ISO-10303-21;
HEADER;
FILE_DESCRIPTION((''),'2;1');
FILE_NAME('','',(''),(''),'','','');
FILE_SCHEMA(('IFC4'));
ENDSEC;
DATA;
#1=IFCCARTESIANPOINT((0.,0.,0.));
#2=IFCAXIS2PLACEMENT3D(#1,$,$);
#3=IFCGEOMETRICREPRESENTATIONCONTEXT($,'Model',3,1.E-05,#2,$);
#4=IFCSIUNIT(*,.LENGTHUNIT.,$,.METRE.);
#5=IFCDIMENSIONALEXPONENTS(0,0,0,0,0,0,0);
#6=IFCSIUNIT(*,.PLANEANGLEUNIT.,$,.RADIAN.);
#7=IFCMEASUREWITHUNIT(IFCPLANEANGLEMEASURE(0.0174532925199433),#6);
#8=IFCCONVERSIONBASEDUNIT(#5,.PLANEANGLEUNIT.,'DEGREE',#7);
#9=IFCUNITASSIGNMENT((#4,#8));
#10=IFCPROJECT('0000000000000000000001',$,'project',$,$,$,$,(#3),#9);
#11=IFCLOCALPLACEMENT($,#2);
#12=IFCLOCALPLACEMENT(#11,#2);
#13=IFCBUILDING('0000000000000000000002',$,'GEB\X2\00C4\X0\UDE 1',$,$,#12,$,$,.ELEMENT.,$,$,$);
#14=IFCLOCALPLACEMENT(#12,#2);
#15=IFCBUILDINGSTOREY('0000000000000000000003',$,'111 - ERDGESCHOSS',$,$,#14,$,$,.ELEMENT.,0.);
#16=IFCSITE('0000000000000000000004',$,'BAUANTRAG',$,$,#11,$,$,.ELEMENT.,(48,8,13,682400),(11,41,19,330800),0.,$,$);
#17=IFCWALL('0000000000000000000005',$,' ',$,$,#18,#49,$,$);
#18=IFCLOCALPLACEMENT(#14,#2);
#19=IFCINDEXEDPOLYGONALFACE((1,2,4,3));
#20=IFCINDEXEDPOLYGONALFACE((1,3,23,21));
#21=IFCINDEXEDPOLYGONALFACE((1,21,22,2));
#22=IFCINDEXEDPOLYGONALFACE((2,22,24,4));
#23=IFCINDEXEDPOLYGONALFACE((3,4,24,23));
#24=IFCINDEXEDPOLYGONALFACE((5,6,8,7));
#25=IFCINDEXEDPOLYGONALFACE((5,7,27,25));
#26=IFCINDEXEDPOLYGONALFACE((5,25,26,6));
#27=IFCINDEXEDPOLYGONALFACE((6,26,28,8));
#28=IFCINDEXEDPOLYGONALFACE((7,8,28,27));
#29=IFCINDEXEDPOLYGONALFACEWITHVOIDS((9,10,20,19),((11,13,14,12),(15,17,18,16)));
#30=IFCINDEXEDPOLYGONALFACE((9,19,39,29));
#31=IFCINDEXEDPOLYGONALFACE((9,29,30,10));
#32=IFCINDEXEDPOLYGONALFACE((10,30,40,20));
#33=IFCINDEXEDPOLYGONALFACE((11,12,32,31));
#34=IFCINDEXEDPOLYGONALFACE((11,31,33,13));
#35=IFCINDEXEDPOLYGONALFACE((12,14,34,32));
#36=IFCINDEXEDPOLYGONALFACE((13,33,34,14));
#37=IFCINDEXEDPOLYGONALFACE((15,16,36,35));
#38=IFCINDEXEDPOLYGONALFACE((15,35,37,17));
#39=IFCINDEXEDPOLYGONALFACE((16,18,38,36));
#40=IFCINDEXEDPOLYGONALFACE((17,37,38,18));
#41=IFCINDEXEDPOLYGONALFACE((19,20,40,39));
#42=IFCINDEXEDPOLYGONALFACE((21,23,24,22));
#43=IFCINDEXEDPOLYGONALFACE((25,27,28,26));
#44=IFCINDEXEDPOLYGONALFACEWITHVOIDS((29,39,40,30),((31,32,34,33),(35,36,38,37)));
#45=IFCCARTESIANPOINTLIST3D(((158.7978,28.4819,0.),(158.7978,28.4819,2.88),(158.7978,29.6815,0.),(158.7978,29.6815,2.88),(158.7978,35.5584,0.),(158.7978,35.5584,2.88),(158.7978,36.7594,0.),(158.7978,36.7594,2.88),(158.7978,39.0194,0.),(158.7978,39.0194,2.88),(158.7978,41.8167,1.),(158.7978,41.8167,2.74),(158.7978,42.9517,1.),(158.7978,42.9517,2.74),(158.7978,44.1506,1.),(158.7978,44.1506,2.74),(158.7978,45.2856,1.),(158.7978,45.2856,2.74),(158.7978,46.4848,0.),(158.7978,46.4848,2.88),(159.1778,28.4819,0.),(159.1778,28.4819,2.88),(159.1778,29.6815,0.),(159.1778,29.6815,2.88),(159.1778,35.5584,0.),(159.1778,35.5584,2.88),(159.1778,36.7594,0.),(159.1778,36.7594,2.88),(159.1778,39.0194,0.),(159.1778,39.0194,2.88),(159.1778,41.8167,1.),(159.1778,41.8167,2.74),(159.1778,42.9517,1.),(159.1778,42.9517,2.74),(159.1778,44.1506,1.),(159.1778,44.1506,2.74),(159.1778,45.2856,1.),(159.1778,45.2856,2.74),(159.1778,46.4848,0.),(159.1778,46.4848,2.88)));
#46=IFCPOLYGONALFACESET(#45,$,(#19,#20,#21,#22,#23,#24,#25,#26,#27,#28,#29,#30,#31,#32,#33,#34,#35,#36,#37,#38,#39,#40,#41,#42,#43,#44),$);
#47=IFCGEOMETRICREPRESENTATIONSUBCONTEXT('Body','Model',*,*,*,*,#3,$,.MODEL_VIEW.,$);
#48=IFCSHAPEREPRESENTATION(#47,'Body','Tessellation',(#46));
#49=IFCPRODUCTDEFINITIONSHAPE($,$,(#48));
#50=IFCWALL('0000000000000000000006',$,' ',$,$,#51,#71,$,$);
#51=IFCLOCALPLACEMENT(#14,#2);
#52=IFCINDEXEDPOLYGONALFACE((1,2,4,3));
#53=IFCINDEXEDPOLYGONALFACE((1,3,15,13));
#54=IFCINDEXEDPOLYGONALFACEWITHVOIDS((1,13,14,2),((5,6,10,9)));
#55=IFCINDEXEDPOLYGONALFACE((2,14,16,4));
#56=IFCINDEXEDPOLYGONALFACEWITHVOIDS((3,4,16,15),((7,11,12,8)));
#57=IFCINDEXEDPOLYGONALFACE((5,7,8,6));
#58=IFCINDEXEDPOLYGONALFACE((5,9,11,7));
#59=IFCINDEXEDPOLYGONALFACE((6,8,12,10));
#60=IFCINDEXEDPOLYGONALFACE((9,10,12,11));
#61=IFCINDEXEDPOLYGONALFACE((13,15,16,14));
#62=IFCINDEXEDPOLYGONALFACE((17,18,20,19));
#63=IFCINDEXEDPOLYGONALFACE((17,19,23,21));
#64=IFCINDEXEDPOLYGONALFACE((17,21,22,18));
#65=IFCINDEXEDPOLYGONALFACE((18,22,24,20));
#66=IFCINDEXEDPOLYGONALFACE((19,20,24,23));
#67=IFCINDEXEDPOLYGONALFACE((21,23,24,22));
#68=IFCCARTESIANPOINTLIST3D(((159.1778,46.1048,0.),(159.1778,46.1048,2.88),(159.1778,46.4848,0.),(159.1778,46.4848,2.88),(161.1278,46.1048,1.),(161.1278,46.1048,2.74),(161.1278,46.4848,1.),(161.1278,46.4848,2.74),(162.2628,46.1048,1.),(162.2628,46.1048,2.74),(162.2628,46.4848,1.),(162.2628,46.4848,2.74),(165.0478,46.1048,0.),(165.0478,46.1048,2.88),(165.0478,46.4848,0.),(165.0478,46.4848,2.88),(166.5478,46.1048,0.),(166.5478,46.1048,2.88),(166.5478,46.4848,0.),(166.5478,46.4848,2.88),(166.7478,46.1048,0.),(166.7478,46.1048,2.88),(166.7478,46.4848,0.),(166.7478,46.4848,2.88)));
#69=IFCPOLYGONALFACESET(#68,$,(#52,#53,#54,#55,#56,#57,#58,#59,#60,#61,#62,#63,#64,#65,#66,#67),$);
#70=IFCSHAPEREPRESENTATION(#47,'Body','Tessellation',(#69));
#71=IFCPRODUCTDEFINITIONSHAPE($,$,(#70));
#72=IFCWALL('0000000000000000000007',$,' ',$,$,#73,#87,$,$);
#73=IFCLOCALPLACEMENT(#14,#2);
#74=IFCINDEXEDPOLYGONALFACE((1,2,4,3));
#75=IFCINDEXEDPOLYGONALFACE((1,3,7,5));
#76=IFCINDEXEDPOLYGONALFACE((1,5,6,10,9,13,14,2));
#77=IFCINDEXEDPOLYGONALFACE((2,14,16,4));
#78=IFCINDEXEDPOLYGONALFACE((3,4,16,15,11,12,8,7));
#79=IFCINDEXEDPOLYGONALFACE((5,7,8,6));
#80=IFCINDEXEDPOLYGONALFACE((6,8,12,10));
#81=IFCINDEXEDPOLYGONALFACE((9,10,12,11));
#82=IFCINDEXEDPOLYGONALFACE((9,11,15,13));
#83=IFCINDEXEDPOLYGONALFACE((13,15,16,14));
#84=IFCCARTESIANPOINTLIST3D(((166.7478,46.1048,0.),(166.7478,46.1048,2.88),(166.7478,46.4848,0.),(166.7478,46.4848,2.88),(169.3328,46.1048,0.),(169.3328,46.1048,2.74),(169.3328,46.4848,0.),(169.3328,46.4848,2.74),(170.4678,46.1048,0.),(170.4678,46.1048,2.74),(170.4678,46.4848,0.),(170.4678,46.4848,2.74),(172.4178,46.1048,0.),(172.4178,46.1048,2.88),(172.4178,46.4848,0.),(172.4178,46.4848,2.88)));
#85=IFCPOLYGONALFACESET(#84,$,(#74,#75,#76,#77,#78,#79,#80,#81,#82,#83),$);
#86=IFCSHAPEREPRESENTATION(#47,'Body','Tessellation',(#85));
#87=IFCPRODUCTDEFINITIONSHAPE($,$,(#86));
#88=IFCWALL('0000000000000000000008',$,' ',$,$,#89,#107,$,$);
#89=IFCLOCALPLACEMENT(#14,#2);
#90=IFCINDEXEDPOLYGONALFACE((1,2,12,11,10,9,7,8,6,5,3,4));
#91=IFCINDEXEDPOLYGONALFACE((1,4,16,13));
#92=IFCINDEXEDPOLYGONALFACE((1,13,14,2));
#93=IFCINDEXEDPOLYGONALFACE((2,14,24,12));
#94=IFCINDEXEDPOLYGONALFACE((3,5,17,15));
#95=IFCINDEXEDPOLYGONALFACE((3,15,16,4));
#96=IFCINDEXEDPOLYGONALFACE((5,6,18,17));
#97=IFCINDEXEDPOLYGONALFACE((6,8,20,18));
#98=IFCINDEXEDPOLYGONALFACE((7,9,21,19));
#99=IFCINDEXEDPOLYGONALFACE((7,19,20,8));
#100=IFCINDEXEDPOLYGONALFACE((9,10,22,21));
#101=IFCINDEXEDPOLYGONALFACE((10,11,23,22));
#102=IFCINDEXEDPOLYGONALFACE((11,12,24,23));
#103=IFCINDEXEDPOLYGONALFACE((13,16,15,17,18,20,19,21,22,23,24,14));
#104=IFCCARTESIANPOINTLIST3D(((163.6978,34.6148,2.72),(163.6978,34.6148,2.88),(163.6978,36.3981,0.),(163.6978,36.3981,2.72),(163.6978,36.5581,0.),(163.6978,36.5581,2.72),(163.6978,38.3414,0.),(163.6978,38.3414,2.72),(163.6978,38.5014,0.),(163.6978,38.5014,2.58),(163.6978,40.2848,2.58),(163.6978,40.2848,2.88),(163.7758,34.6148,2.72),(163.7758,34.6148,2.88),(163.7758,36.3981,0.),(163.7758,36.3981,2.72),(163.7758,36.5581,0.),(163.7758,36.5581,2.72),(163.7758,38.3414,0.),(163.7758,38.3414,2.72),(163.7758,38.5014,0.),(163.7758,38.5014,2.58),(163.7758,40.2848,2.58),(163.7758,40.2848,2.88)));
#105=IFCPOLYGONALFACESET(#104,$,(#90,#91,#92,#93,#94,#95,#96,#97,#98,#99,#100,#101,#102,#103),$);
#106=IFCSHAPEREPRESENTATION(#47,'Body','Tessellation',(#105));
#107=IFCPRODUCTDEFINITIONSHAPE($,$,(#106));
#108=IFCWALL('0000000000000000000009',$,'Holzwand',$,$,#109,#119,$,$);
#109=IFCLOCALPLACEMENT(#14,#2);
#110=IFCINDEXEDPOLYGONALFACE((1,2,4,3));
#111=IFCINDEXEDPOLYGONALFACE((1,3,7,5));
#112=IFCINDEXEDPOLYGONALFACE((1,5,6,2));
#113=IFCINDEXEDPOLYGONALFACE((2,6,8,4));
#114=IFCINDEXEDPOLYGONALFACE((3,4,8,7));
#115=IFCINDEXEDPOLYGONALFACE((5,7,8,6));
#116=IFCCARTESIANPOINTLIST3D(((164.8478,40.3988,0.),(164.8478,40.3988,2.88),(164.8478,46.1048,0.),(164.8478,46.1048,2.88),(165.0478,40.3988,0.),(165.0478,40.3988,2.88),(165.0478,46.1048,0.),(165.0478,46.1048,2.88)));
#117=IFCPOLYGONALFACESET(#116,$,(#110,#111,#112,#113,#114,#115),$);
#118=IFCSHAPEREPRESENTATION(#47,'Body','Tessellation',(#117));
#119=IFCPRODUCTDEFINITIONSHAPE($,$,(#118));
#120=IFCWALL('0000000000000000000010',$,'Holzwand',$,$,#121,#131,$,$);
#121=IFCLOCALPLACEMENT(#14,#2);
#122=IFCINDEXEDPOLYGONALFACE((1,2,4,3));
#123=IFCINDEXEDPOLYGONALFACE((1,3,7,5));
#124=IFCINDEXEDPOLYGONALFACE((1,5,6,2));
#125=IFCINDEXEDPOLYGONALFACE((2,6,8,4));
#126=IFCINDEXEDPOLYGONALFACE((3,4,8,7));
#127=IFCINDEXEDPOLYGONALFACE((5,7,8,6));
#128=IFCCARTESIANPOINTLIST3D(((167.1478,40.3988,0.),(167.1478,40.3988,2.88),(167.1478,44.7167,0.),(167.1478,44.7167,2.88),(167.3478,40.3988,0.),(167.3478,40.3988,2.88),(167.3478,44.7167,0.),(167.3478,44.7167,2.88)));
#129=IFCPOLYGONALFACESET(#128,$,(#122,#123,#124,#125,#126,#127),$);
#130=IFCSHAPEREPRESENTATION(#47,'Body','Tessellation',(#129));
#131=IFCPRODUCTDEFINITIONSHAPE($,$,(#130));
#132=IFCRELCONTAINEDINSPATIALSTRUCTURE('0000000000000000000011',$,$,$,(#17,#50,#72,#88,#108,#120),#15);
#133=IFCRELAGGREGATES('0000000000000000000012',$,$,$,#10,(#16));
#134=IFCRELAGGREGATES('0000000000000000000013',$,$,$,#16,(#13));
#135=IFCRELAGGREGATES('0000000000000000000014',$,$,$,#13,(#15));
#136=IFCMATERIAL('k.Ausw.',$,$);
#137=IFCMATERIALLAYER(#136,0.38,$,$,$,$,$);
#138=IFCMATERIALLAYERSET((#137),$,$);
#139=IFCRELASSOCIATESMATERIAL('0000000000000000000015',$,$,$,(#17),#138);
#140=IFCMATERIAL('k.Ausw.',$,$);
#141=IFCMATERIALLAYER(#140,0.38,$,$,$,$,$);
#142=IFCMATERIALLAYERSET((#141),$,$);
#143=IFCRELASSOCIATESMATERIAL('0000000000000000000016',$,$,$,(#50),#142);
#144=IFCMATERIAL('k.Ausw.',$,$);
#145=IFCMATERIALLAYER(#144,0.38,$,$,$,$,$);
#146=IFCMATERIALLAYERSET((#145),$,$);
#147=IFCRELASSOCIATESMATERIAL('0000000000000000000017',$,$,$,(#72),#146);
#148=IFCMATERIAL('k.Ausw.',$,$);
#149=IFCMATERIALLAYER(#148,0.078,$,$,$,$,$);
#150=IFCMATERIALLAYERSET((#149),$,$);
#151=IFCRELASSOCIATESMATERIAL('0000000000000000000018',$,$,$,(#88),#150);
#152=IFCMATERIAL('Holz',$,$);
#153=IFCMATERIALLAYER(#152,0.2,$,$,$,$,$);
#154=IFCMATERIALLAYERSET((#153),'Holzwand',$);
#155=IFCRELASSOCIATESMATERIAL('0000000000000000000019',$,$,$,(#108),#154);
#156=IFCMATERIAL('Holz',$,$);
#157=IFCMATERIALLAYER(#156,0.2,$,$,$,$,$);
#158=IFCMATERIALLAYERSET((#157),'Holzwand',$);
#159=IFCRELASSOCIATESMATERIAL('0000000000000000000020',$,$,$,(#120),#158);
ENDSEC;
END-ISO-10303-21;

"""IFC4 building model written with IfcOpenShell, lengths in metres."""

from ifc_helpers import new_model, entity, si_unit, converted_unit, frame, frame_2d, origin, origin_with_axes, place, context, subcontext, project, spatial, polyline, rectangle, outline, extrude, material, layer, layer_set, layer_usage, element, save


model = new_model("IFC4")

# Units and contexts
model_context = context("Model", 3, precision=1e-05, world=origin())
body_context = subcontext(model_context, "Body", "Model", "MODEL_VIEW")
ifc_project = project(units=[si_unit("LENGTHUNIT", "METRE"), converted_unit("PLANEANGLEUNIT", "DEGREE", entity("IfcPlaneAngleMeasure", 0.0174532925199433), si_unit("PLANEANGLEUNIT", "RADIAN"), dimensions=[0, 0, 0, 0, 0, 0, 0])], contexts=[model_context])

# Site, building, storey
site_placement = place(None, origin())
site = spatial("IfcSite", under=ifc_project, at=site_placement, Name="BAUANTRAG", CompositionType="ELEMENT", RefLatitude=(48, 8, 13, 682400), RefLongitude=(11, 41, 19, 330800), RefElevation=0.0)
building_placement = place(site_placement, origin())
building = spatial("IfcBuilding", under=site, at=building_placement, Name="GEBÄUDE 1", CompositionType="ELEMENT")
storey_placement = place(building_placement, origin())
storey = spatial("IfcBuildingStorey", under=building, at=storey_placement, Name="111 - ERDGESCHOSS", CompositionType="ELEMENT", Elevation=0.0)

# Walls, openings
ifc_material_1 = material(Name="k.Ausw.")
ifc_layer_1 = layer(ifc_material_1, 0.38)
ifc_layer_set_1 = layer_set([ifc_layer_1])
ifc_layer_usage_1 = layer_usage(ifc_layer_set_1, "AXIS2", "POSITIVE", 0.0)
wall_1_placement = place(storey_placement, frame((158.7978, 46.4848, 0.0), z_axis=(0.0, 0.0, 1.0), x_axis=(0.0, -1.0, 0.0)))
wall_1 = element("IfcWall", 1, at=wall_1_placement, inside=storey, material=ifc_layer_usage_1, Name=" ", context=body_context, shape_type="SweptSolid", body=[
    extrude(rectangle(XDim=18.0029, YDim=0.38, at=frame_2d((9.0014, 0.19), x_axis=(1.0, 0.0))), origin_with_axes(), (0.0, 0.0, 1.0), 2.88),
])
opening_1_placement = place(wall_1_placement, frame((1.1992, 0.0, 1.0), z_axis=(0.0, 1.0, 0.0), x_axis=(0.0, 0.0, 1.0)))
element("IfcOpeningElement", 2, at=opening_1_placement, cuts=wall_1, ObjectType="Opening", context=body_context, shape_type="SweptSolid", body=[
    extrude(outline(polyline([(0.0, 1.135), (1.74, 1.135), (1.74, 0.0), (0.0, 0.0), (0.0, 1.135)])), origin_with_axes(), (0.0, 0.0, 1.0), 0.38),
])
opening_2_placement = place(wall_1_placement, frame((3.5331, 0.0, 1.0), z_axis=(0.0, 1.0, 0.0), x_axis=(0.0, 0.0, 1.0)))
element("IfcOpeningElement", 3, at=opening_2_placement, cuts=wall_1, ObjectType="Opening", context=body_context, shape_type="SweptSolid", body=[
    extrude(outline(polyline([(0.0, 1.135), (1.74, 1.135), (1.74, 0.0), (0.0, 0.0), (0.0, 1.135)])), origin_with_axes(), (0.0, 0.0, 1.0), 0.38),
])
opening_3_placement = place(wall_1_placement, frame((12.0614, 0.0, 0.0), z_axis=(0.0, 1.0, 0.0), x_axis=(0.0, 0.0, 1.0)))
element("IfcOpeningElement", 4, at=opening_3_placement, cuts=wall_1, ObjectType="Opening", context=body_context, shape_type="SweptSolid", body=[
    extrude(outline(polyline([(0.0, 3.608), (2.88, 3.608), (2.88, 0.0), (0.0, 0.0), (0.0, 3.608)])), origin_with_axes(), (0.0, 0.0, 1.0), 0.38),
])
opening_4_placement = place(wall_1_placement, frame((10.9264, 0.0, 0.0), z_axis=(0.0, 1.0, 0.0), x_axis=(0.0, 0.0, 1.0)))
element("IfcOpeningElement", 5, at=opening_4_placement, cuts=wall_1, ObjectType="Opening", context=body_context, shape_type="SweptSolid", body=[
    extrude(outline(polyline([(0.0, 1.135), (2.88, 1.135), (2.88, 0.0), (0.0, 0.0), (0.0, 1.135)])), origin_with_axes(), (0.0, 0.0, 1.0), 0.38),
])
opening_5_placement = place(wall_1_placement, frame((15.6683, 0.0, 0.0), z_axis=(0.0, 1.0, 0.0), x_axis=(0.0, 0.0, 1.0)))
element("IfcOpeningElement", 6, at=opening_5_placement, cuts=wall_1, ObjectType="Opening", context=body_context, shape_type="SweptSolid", body=[
    extrude(outline(polyline([(0.0, 1.135), (2.88, 1.135), (2.88, 0.0), (0.0, 0.0), (0.0, 1.135)])), origin_with_axes(), (0.0, 0.0, 1.0), 0.38),
])
opening_6_placement = place(wall_1_placement, frame((7.4654, 0.0, 0.0), z_axis=(0.0, 1.0, 0.0), x_axis=(0.0, 0.0, 1.0)))
element("IfcOpeningElement", 7, at=opening_6_placement, cuts=wall_1, ObjectType="Opening", context=body_context, shape_type="SweptSolid", body=[
    extrude(outline(polyline([(0.0, 2.26), (2.88, 2.26), (2.88, 0.0), (0.0, 0.0), (0.0, 2.26)])), origin_with_axes(), (0.0, 0.0, 1.0), 0.38),
])
ifc_material_2 = material(Name="k.Ausw.")
ifc_layer_2 = layer(ifc_material_2, 0.38)
ifc_layer_set_2 = layer_set([ifc_layer_2])
ifc_layer_usage_2 = layer_usage(ifc_layer_set_2, "AXIS2", "POSITIVE", 0.0)
wall_2_placement = place(storey_placement, frame((166.7478, 46.4848, 0.0), z_axis=(0.0, 0.0, 1.0), x_axis=(-1.0, 0.0, 0.0)))
wall_2 = element("IfcWall", 8, at=wall_2_placement, inside=storey, material=ifc_layer_usage_2, Name=" ", context=body_context, shape_type="SweptSolid", body=[
    extrude(rectangle(XDim=7.57, YDim=0.38, at=frame_2d((3.785, 0.19), x_axis=(1.0, 0.0))), origin_with_axes(), (0.0, 0.0, 1.0), 2.88),
])
opening_7_placement = place(wall_2_placement, frame((0.2, 0.0, -0.15), z_axis=(0.0, 1.0, 0.0), x_axis=(0.0, 0.0, 1.0)))
element("IfcOpeningElement", 9, at=opening_7_placement, cuts=wall_2, ObjectType="Opening", context=body_context, shape_type="SweptSolid", body=[
    extrude(outline(polyline([(0.0, 1.5), (3.03, 1.5), (3.03, 0.0), (0.0, 0.0), (0.0, 1.5)])), origin_with_axes(), (0.0, 0.0, 1.0), 0.38),
])
opening_8_placement = place(wall_2_placement, frame((5.62, 0.38, 1.0), z_axis=(0.0, -1.0, 0.0), x_axis=(0.0, 0.0, 1.0)))
element("IfcOpeningElement", 10, at=opening_8_placement, cuts=wall_2, ObjectType="Opening", context=body_context, shape_type="SweptSolid", body=[
    extrude(outline(polyline([(0.0, 1.135), (1.74, 1.135), (1.74, 0.0), (0.0, 0.0), (0.0, 1.135)])), origin_with_axes(), (0.0, 0.0, 1.0), 0.38),
])

# Wall, opening
ifc_material_3 = material(Name="k.Ausw.")
ifc_layer_3 = layer(ifc_material_3, 0.38)
ifc_layer_set_3 = layer_set([ifc_layer_3])
ifc_layer_usage_3 = layer_usage(ifc_layer_set_3, "AXIS2", "POSITIVE", 0.0)
wall_3_placement = place(storey_placement, frame((172.4178, 46.4848, 0.0), z_axis=(0.0, 0.0, 1.0), x_axis=(-1.0, 0.0, 0.0)))
wall_3 = element("IfcWall", 11, at=wall_3_placement, inside=storey, material=ifc_layer_usage_3, Name=" ", context=body_context, shape_type="SweptSolid", body=[
    extrude(rectangle(XDim=5.67, YDim=0.38, at=frame_2d((2.835, 0.19), x_axis=(1.0, 0.0))), origin_with_axes(), (0.0, 0.0, 1.0), 2.88),
])
opening_9_placement = place(wall_3_placement, frame((3.085, 0.38, 0.0), z_axis=(0.0, -1.0, 0.0), x_axis=(0.0, 0.0, 1.0)))
element("IfcOpeningElement", 12, at=opening_9_placement, cuts=wall_3, ObjectType="Opening", context=body_context, shape_type="SweptSolid", body=[
    extrude(outline(polyline([(0.0, 1.135), (2.74, 1.135), (2.74, 0.0), (0.0, 0.0), (0.0, 1.135)])), origin_with_axes(), (0.0, 0.0, 1.0), 0.38),
])

# Wall, openings
ifc_material_4 = material(Name="k.Ausw.")
ifc_layer_4 = layer(ifc_material_4, 0.078)
ifc_layer_set_4 = layer_set([ifc_layer_4])
ifc_layer_usage_4 = layer_usage(ifc_layer_set_4, "AXIS2", "POSITIVE", 0.0)
wall_4_placement = place(storey_placement, frame((163.6978, 40.2848, 0.0), z_axis=(0.0, 0.0, 1.0), x_axis=(0.0, -1.0, 0.0)))
wall_4 = element("IfcWall", 13, at=wall_4_placement, inside=storey, material=ifc_layer_usage_4, Name=" ", context=body_context, shape_type="SweptSolid", body=[
    extrude(rectangle(XDim=5.67, YDim=0.078, at=frame_2d((2.835, 0.039), x_axis=(1.0, 0.0))), origin_with_axes(), (0.0, 0.0, 1.0), 2.88),
])
opening_10_placement = place(wall_4_placement, frame((3.8867, 0.0, 0.0), z_axis=(0.0, 1.0, 0.0), x_axis=(0.0, 0.0, 1.0)))
element("IfcOpeningElement", 14, at=opening_10_placement, cuts=wall_4, ObjectType="Opening", context=body_context, shape_type="SweptSolid", body=[
    extrude(outline(polyline([(0.0, 1.7833), (2.72, 1.7833), (2.72, 0.0), (0.0, 0.0), (0.0, 1.7833)])), origin_with_axes(), (0.0, 0.0, 1.0), 0.078),
])
opening_11_placement = place(wall_4_placement, frame((0.0, 0.0, -0.14), z_axis=(0.0, 1.0, 0.0), x_axis=(0.0, 0.0, 1.0)))
element("IfcOpeningElement", 15, at=opening_11_placement, cuts=wall_4, ObjectType="Opening", context=body_context, shape_type="SweptSolid", body=[
    extrude(outline(polyline([(0.0, 1.7834), (2.72, 1.7834), (2.72, 0.0), (0.0, 0.0), (0.0, 1.7834)])), origin_with_axes(), (0.0, 0.0, 1.0), 0.078),
])
opening_12_placement = place(wall_4_placement, frame((1.9434, 0.0, 0.0), z_axis=(0.0, 1.0, 0.0), x_axis=(0.0, 0.0, 1.0)))
element("IfcOpeningElement", 16, at=opening_12_placement, cuts=wall_4, ObjectType="Opening", context=body_context, shape_type="SweptSolid", body=[
    extrude(outline(polyline([(0.0, 1.7833), (2.72, 1.7833), (2.72, 0.0), (0.0, 0.0), (0.0, 1.7833)])), origin_with_axes(), (0.0, 0.0, 1.0), 0.078),
])

# Walls
ifc_material_5 = material(Name="Holz")
ifc_layer_5 = layer(ifc_material_5, 0.2)
ifc_layer_set_5 = layer_set([ifc_layer_5], Name="Holzwand")
ifc_layer_usage_5 = layer_usage(ifc_layer_set_5, "AXIS2", "POSITIVE", 0.0)
wall_5_placement = place(storey_placement, frame((164.8478, 46.1048, 0.0), z_axis=(0.0, 0.0, 1.0), x_axis=(0.0, -1.0, 0.0)))
element("IfcWall", 17, at=wall_5_placement, inside=storey, material=ifc_layer_usage_5, Name="Holzwand", context=body_context, shape_type="SweptSolid", body=[
    extrude(rectangle(XDim=5.706, YDim=0.2, at=frame_2d((2.853, 0.1), x_axis=(1.0, 0.0))), origin_with_axes(), (0.0, 0.0, 1.0), 2.88),
])
ifc_material_6 = material(Name="Holz")
ifc_layer_6 = layer(ifc_material_6, 0.2)
ifc_layer_set_6 = layer_set([ifc_layer_6], Name="Holzwand")
ifc_layer_usage_6 = layer_usage(ifc_layer_set_6, "AXIS2", "POSITIVE", 0.0)
wall_6_placement = place(storey_placement, frame((167.1478, 44.7167, 0.0), z_axis=(0.0, 0.0, 1.0), x_axis=(0.0, -1.0, 0.0)))
element("IfcWall", 18, at=wall_6_placement, inside=storey, material=ifc_layer_usage_6, Name="Holzwand", context=body_context, shape_type="SweptSolid", body=[
    extrude(rectangle(XDim=4.3179, YDim=0.2, at=frame_2d((2.1589, 0.1), x_axis=(1.0, 0.0))), origin_with_axes(), (0.0, 0.0, 1.0), 2.88),
])

save(model, "model.ifc")
